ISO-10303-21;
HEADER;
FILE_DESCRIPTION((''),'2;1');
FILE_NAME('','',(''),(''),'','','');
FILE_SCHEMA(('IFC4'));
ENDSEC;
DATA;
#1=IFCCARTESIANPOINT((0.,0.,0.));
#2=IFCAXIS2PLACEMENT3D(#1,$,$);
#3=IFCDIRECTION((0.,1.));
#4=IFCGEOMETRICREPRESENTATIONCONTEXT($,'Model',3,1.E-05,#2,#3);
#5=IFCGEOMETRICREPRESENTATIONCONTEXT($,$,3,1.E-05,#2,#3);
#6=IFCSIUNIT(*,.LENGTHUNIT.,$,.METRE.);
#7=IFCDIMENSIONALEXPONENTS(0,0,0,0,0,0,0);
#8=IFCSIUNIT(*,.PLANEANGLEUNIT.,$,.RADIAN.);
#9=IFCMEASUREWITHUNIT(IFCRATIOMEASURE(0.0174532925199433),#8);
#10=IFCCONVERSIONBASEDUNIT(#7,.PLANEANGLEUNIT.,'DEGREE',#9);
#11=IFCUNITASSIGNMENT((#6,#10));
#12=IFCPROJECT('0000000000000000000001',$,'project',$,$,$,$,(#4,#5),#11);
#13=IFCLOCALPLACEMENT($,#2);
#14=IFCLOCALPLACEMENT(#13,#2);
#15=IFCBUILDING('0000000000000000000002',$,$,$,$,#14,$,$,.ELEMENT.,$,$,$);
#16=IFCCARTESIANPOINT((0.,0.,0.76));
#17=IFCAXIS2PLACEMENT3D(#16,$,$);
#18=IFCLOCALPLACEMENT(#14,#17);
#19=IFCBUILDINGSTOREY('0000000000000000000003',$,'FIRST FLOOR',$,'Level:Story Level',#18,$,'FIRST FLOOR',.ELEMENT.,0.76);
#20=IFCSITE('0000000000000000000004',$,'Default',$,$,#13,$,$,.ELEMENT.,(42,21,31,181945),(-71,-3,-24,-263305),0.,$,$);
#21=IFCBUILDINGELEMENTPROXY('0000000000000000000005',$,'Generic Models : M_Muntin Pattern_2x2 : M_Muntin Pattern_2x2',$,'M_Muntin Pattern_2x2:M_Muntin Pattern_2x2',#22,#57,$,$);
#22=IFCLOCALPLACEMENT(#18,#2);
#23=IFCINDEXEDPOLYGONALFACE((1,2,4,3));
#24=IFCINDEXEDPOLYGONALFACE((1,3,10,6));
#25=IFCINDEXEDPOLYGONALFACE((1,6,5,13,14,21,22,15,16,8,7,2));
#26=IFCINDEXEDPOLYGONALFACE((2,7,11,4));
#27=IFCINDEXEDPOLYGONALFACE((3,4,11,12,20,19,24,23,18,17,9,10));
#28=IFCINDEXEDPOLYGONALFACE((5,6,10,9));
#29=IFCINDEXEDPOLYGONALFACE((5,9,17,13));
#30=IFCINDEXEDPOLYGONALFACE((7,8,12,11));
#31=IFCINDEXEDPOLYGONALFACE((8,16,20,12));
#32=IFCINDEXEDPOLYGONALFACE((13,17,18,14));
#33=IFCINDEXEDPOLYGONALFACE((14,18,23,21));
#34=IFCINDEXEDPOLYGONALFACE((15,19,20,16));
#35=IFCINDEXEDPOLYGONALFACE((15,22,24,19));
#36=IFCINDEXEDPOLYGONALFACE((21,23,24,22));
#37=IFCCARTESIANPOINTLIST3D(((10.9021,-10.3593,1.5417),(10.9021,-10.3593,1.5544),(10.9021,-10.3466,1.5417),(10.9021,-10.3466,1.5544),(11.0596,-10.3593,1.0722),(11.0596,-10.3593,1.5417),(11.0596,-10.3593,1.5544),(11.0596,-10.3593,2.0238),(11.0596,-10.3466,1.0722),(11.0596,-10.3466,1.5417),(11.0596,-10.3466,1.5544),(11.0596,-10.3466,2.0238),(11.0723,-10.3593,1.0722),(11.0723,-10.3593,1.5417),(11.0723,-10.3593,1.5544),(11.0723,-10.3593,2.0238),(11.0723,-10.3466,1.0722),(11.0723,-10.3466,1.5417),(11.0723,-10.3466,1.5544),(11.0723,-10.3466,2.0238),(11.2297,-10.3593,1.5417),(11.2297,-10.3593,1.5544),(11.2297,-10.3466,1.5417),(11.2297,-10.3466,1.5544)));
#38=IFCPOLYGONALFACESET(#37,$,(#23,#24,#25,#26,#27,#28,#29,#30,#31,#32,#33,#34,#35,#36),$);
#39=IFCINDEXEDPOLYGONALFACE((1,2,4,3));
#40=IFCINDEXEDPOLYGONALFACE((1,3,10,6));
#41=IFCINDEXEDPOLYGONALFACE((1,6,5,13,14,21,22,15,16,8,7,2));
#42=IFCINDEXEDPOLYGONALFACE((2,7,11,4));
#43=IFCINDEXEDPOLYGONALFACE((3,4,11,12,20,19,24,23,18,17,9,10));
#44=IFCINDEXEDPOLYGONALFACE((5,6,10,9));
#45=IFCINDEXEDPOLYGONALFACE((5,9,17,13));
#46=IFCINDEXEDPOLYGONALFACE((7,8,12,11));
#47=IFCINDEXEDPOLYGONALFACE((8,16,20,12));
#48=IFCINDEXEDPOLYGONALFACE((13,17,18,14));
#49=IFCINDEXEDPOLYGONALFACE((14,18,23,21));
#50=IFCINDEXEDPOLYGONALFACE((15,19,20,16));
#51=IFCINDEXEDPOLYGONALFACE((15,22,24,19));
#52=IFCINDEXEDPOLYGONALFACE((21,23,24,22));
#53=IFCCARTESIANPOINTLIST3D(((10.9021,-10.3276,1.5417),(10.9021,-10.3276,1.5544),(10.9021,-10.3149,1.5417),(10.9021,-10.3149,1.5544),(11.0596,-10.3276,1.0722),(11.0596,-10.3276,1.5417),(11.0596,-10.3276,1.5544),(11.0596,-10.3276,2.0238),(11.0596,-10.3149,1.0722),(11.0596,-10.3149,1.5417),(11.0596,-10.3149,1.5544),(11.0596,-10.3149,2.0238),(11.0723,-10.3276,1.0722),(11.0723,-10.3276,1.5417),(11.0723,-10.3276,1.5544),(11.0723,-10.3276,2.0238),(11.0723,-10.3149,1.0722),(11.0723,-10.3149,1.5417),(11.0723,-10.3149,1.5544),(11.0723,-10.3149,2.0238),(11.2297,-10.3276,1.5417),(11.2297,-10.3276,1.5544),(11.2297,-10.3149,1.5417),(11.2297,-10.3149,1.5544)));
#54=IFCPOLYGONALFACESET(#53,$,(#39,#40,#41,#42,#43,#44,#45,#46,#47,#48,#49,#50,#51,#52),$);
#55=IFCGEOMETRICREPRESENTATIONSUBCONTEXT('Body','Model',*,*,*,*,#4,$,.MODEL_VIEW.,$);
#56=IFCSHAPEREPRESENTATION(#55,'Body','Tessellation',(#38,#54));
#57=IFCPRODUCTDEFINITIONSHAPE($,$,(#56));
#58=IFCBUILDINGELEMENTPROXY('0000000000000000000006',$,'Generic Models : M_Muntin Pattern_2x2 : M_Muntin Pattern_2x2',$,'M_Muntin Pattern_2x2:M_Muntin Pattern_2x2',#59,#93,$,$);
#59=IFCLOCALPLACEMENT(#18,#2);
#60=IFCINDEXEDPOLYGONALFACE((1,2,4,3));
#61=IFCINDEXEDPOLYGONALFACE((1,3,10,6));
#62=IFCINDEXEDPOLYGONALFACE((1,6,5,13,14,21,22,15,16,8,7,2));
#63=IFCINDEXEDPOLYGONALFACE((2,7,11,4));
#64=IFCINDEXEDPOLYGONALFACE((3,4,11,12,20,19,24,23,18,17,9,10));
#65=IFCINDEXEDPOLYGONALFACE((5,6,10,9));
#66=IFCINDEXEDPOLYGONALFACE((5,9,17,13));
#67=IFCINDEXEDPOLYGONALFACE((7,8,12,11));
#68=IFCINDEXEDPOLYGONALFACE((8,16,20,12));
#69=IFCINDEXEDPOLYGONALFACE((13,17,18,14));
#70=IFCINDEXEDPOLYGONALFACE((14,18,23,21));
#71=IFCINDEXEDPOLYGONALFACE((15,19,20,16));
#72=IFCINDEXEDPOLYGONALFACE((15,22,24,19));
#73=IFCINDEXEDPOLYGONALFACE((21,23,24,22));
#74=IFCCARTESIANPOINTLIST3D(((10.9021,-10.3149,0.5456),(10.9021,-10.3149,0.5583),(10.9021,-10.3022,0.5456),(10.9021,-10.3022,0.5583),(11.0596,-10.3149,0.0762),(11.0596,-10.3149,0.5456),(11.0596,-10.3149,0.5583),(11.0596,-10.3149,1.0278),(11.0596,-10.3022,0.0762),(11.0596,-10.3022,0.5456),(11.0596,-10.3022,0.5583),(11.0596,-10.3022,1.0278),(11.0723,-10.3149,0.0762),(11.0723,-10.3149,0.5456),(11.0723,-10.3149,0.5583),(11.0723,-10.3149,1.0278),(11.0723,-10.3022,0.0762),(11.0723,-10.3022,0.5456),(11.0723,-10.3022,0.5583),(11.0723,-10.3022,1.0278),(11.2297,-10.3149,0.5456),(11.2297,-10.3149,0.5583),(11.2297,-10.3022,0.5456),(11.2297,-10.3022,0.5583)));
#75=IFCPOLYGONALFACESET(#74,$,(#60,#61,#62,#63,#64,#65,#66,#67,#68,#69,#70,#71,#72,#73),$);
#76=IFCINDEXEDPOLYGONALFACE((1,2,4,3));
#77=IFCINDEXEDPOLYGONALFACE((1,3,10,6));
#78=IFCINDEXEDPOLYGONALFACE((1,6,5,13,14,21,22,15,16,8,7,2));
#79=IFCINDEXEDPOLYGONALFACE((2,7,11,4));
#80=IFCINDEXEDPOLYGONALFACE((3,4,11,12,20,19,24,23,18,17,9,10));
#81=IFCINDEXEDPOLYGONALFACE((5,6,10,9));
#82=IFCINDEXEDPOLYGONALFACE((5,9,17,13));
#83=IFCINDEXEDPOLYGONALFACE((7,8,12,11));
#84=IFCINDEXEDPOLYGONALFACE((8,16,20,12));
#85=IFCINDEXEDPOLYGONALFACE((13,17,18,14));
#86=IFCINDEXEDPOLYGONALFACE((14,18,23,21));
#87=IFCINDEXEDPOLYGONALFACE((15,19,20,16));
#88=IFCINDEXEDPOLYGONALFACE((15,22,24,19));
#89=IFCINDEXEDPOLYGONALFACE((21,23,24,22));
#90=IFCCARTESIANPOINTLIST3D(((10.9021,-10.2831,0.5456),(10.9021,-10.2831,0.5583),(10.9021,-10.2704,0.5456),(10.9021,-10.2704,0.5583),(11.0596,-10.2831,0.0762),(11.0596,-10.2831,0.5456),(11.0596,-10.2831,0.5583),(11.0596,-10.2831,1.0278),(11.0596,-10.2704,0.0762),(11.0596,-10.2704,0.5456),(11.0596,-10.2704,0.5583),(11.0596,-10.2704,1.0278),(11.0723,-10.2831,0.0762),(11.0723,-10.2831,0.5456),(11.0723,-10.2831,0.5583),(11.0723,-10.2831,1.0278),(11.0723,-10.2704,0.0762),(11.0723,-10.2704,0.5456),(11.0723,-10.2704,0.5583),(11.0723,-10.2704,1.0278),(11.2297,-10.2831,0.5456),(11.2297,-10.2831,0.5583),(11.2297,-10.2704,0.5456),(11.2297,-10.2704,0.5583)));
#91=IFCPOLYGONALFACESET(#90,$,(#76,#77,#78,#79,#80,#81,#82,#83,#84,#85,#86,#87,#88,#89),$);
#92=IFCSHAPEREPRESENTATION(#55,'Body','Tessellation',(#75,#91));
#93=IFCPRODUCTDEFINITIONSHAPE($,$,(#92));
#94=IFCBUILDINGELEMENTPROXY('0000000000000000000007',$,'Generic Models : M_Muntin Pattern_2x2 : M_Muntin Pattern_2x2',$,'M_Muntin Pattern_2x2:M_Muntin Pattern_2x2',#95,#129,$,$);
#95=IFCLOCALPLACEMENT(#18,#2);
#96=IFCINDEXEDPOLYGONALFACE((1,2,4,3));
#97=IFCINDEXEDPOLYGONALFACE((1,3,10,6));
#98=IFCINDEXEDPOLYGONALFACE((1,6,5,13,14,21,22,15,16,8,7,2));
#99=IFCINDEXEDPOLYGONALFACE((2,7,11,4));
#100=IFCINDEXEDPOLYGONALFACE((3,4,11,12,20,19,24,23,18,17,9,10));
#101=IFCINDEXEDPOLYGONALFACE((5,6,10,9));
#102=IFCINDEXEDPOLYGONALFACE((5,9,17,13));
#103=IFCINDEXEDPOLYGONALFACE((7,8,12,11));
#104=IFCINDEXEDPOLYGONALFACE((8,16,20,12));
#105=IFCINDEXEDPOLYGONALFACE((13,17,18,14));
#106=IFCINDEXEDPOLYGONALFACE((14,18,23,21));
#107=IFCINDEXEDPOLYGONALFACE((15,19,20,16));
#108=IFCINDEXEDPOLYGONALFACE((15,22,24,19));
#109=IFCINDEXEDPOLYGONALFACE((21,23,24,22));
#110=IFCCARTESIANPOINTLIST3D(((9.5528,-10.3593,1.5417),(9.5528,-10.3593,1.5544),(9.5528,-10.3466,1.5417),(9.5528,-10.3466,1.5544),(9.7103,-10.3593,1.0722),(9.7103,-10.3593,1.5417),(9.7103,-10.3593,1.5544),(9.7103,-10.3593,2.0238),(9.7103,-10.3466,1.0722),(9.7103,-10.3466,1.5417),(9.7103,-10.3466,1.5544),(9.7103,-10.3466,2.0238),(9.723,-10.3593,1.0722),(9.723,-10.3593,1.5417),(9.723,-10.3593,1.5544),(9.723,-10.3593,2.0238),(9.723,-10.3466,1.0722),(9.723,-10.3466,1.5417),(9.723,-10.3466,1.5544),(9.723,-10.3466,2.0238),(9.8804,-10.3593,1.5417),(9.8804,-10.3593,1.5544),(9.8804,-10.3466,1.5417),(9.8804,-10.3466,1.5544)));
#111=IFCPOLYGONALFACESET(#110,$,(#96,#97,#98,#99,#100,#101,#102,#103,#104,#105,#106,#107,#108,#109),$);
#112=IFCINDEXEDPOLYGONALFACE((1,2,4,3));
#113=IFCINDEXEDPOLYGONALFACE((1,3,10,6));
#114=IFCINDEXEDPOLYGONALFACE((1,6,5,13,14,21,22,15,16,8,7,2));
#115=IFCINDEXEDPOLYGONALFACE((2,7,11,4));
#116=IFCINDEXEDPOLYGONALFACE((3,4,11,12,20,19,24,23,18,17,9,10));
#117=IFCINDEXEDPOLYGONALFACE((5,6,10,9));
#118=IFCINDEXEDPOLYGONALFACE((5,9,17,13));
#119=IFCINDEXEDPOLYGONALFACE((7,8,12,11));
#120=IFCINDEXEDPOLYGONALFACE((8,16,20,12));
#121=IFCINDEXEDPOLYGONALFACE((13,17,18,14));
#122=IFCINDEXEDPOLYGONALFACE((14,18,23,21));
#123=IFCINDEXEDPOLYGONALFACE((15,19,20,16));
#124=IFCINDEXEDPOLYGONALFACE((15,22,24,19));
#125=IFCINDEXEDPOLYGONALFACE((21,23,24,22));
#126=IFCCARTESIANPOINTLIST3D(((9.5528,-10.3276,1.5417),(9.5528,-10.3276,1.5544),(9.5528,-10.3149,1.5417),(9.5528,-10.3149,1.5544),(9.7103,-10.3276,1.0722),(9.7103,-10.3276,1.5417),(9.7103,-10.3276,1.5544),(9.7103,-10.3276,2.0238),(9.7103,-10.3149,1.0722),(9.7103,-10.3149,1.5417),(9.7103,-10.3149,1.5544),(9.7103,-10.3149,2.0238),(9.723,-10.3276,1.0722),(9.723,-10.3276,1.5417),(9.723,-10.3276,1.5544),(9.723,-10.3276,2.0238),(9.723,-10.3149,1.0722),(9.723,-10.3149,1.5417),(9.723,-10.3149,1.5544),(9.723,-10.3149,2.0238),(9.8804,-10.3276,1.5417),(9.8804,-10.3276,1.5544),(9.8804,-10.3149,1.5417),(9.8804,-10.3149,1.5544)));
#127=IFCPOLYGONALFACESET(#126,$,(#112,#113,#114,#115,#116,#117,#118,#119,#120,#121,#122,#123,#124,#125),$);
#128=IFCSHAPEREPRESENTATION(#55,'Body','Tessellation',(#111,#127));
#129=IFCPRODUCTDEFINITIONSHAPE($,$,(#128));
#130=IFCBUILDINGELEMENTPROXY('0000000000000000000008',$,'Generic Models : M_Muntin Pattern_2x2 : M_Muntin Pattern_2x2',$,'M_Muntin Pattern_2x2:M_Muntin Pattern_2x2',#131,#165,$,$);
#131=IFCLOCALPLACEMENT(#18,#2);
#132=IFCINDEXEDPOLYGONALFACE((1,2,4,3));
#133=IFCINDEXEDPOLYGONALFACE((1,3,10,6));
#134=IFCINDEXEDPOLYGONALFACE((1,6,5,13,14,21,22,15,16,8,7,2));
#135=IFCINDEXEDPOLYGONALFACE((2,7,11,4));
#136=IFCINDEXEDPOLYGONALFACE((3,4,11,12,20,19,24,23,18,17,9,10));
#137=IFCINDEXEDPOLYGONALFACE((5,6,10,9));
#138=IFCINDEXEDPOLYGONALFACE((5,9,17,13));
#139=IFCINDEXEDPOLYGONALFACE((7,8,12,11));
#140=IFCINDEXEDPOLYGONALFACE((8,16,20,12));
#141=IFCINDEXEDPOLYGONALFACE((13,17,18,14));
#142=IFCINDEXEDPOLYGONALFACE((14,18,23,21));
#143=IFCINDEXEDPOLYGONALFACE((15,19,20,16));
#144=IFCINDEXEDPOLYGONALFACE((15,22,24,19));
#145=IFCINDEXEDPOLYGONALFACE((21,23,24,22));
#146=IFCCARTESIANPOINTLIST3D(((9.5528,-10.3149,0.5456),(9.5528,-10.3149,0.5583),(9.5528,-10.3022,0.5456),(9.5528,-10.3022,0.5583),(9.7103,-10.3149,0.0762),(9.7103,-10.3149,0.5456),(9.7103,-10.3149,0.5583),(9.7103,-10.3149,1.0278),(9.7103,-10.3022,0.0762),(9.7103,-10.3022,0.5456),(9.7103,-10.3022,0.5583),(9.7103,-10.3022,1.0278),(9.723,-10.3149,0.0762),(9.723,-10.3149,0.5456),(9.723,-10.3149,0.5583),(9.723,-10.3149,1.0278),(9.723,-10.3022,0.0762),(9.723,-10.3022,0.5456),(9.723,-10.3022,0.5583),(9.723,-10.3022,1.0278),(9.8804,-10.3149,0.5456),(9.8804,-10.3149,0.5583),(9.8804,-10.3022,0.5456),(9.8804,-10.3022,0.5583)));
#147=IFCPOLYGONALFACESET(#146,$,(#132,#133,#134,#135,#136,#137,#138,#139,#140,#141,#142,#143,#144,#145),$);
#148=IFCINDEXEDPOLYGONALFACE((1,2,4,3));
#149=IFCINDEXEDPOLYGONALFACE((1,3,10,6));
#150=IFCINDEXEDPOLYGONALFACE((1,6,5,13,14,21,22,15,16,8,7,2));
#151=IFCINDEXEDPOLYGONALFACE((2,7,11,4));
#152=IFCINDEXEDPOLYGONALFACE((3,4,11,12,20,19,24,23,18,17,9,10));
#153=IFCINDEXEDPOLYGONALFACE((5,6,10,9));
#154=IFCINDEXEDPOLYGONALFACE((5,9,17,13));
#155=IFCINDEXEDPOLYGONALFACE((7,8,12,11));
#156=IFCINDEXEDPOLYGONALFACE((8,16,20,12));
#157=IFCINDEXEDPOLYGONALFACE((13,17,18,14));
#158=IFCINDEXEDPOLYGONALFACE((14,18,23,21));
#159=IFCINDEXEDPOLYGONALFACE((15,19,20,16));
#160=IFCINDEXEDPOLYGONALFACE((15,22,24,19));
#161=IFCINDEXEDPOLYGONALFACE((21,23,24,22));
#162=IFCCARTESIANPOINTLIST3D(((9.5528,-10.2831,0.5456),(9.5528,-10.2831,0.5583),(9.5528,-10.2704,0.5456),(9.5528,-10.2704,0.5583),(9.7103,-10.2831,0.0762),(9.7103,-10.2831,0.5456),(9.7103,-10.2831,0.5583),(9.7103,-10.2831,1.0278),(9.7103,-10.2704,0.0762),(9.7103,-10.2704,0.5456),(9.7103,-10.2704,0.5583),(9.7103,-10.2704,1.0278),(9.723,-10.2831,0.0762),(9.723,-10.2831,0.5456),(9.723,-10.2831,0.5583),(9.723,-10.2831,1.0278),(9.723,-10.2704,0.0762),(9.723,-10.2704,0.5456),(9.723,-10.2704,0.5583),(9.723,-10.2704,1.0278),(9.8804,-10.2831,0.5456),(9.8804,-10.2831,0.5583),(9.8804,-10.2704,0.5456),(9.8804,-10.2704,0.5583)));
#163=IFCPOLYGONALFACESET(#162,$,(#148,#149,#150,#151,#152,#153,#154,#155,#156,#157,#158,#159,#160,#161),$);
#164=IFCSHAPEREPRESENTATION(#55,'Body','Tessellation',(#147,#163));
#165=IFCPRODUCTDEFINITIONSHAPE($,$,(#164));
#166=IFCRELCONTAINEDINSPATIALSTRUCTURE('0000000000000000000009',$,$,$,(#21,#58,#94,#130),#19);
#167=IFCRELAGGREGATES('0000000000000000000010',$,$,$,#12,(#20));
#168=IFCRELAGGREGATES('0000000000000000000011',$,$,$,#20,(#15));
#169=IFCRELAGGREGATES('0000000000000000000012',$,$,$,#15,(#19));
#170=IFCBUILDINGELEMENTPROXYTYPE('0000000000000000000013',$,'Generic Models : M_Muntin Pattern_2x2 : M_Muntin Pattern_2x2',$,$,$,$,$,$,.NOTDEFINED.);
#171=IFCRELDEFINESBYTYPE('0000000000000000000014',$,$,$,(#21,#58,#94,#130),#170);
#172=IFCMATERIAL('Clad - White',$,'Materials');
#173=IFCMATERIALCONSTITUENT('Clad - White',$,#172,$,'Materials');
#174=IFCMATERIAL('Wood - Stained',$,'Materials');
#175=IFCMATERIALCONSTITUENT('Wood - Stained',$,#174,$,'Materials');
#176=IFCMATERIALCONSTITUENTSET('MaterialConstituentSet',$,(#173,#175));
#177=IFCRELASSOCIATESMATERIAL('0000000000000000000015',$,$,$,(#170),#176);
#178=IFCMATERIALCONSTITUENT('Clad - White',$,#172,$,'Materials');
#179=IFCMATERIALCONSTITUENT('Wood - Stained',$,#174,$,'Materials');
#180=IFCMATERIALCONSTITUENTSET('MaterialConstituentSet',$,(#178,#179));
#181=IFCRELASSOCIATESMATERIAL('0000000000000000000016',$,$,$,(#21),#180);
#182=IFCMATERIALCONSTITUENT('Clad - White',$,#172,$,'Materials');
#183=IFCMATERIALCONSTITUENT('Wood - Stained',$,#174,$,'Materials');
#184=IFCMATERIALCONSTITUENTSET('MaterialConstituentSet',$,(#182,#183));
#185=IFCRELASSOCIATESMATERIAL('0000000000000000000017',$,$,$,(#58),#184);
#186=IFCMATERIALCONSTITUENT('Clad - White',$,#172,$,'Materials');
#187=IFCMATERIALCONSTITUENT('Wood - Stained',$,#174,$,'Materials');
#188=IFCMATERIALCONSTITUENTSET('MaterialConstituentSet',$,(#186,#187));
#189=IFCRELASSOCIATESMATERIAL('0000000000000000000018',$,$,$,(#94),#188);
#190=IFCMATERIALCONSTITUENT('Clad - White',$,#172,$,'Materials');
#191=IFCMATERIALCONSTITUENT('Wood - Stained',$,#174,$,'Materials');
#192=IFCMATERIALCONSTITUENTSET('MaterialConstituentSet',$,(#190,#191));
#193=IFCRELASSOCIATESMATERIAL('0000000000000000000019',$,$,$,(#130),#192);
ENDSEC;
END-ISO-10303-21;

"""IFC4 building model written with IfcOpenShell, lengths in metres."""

from ifc_helpers import new_model, entity, si_unit, converted_unit, direction, frame, origin, place, context, subcontext, project, spatial, polyline, outline, extrude, source, transform, mapped, material, constituent, constituent_set, type_object, type_shapes, element, save


model = new_model("IFC4")

# Units and contexts
model_context = context("Model", 3, precision=1e-05, world=origin(), true_north=direction((0.0, 1.0)))
context_of_model = context(None, 3, precision=1e-05, world=origin(), true_north=direction((0.0, 1.0)))
body_context = subcontext(model_context, "Body", "Model", "MODEL_VIEW")
ifc_project = project(units=[si_unit("LENGTHUNIT", "METRE"), converted_unit("PLANEANGLEUNIT", "DEGREE", entity("IfcRatioMeasure", 0.0174532925199433), si_unit("PLANEANGLEUNIT", "RADIAN"), dimensions=[0, 0, 0, 0, 0, 0, 0])], contexts=[model_context, context_of_model])

# Site, building, storey
site_placement = place(None, origin())
site = spatial("IfcSite", under=ifc_project, at=site_placement, Name="Default", CompositionType="ELEMENT", RefLatitude=(42, 21, 31, 181945), RefLongitude=(-71, -3, -24, -263305), RefElevation=0.0)
building_placement = place(site_placement, origin())
building = spatial("IfcBuilding", under=site, at=building_placement, CompositionType="ELEMENT")
storey_placement = place(building_placement, frame((0.0, 0.0, 0.76)))
storey = spatial("IfcBuildingStorey", under=building, at=storey_placement, Name="FIRST FLOOR", ObjectType="Level:Story Level", LongName="FIRST FLOOR", CompositionType="ELEMENT", Elevation=0.76)

# Building element proxies
ifc_material_1 = material(Name="Clad - White", Category="Materials")
ifc_constituent_1 = constituent(ifc_material_1, Name="Clad - White", Category="Materials")
ifc_material_2 = material(Name="Wood - Stained", Category="Materials")
ifc_constituent_2 = constituent(ifc_material_2, Name="Wood - Stained", Category="Materials")
ifc_constituent_set_1 = constituent_set(constituents=[ifc_constituent_1, ifc_constituent_2], Name="MaterialConstituentSet")
ifc_constituent_3 = constituent(ifc_material_1, Name="Clad - White", Category="Materials")
ifc_constituent_4 = constituent(ifc_material_2, Name="Wood - Stained", Category="Materials")
ifc_constituent_set_2 = constituent_set(constituents=[ifc_constituent_3, ifc_constituent_4], Name="MaterialConstituentSet")
building_element_proxy_type_1 = type_object("IfcBuildingElementProxyType", Name="Generic Models : M_Muntin Pattern_2x2 : M_Muntin Pattern_2x2", PredefinedType="NOTDEFINED", material=ifc_constituent_set_2)
shared_shape_1 = source(origin(), body_context, "Body", "SweptSolid", [
    extrude(outline(polyline([(0.0064, -0.0064), (0.4758, -0.0064), (0.4758, 0.0063), (0.0064, 0.0063), (0.0064, 0.1638), (-0.0063, 0.1638), (-0.0063, 0.0063), (-0.4758, 0.0063), (-0.4758, -0.0064), (-0.0063, -0.0064), (-0.0063, -0.1638), (0.0064, -0.1638), (0.0064, -0.0064)])), frame((0.0, 0.0095, 0.4758), z_axis=(0.0, 1.0, 0.0), x_axis=(0.0, 0.0, 1.0)), (0.0, 0.0, 1.0), 0.0127),
    extrude(outline(polyline([(0.0064, -0.0064), (0.4758, -0.0064), (0.4758, 0.0063), (0.0064, 0.0063), (0.0064, 0.1638), (-0.0063, 0.1638), (-0.0063, 0.0063), (-0.4758, 0.0063), (-0.4758, -0.0064), (-0.0063, -0.0064), (-0.0063, -0.1638), (0.0064, -0.1638), (0.0064, -0.0064)])), frame((0.0, -0.0222, 0.4758), z_axis=(0.0, 1.0, 0.0), x_axis=(0.0, 0.0, 1.0)), (0.0, 0.0, 1.0), 0.0127),
])
type_shapes(building_element_proxy_type_1, [shared_shape_1])
proxy_1_placement = place(storey_placement, frame((11.0659, -10.3371, 1.0722), z_axis=(0.0, 0.0, 1.0), x_axis=(-1.0, 0.0, 0.0)))
element("IfcBuildingElementProxy", 1, at=proxy_1_placement, inside=storey, type_object=building_element_proxy_type_1, material=ifc_constituent_set_1, Name="Generic Models : M_Muntin Pattern_2x2 : M_Muntin Pattern_2x2", ObjectType="M_Muntin Pattern_2x2:M_Muntin Pattern_2x2", context=body_context, shape_type="MappedRepresentation", body=[
    mapped(shared_shape_1, transform((0.0, 0.0, 0.0), scale=1.0)),
])
ifc_constituent_5 = constituent(ifc_material_1, Name="Clad - White", Category="Materials")
ifc_constituent_6 = constituent(ifc_material_2, Name="Wood - Stained", Category="Materials")
ifc_constituent_set_3 = constituent_set(constituents=[ifc_constituent_5, ifc_constituent_6], Name="MaterialConstituentSet")
proxy_2_placement = place(storey_placement, frame((11.0659, -10.2926, 0.0762), z_axis=(0.0, 0.0, 1.0), x_axis=(-1.0, 0.0, 0.0)))
element("IfcBuildingElementProxy", 2, at=proxy_2_placement, inside=storey, type_object=building_element_proxy_type_1, material=ifc_constituent_set_3, Name="Generic Models : M_Muntin Pattern_2x2 : M_Muntin Pattern_2x2", ObjectType="M_Muntin Pattern_2x2:M_Muntin Pattern_2x2", context=body_context, shape_type="MappedRepresentation", body=[
    mapped(shared_shape_1, transform((0.0, 0.0, 0.0), scale=1.0)),
])
ifc_constituent_7 = constituent(ifc_material_1, Name="Clad - White", Category="Materials")
ifc_constituent_8 = constituent(ifc_material_2, Name="Wood - Stained", Category="Materials")
ifc_constituent_set_4 = constituent_set(constituents=[ifc_constituent_7, ifc_constituent_8], Name="MaterialConstituentSet")
proxy_3_placement = place(storey_placement, frame((9.7166, -10.3371, 1.0722), z_axis=(0.0, 0.0, 1.0), x_axis=(-1.0, 0.0, 0.0)))
element("IfcBuildingElementProxy", 3, at=proxy_3_placement, inside=storey, type_object=building_element_proxy_type_1, material=ifc_constituent_set_4, Name="Generic Models : M_Muntin Pattern_2x2 : M_Muntin Pattern_2x2", ObjectType="M_Muntin Pattern_2x2:M_Muntin Pattern_2x2", context=body_context, shape_type="MappedRepresentation", body=[
    mapped(shared_shape_1, transform((0.0, 0.0, 0.0), scale=1.0)),
])
ifc_constituent_9 = constituent(ifc_material_1, Name="Clad - White", Category="Materials")
ifc_constituent_10 = constituent(ifc_material_2, Name="Wood - Stained", Category="Materials")
ifc_constituent_set_5 = constituent_set(constituents=[ifc_constituent_9, ifc_constituent_10], Name="MaterialConstituentSet")
proxy_4_placement = place(storey_placement, frame((9.7166, -10.2926, 0.0762), z_axis=(0.0, 0.0, 1.0), x_axis=(-1.0, 0.0, 0.0)))
element("IfcBuildingElementProxy", 4, at=proxy_4_placement, inside=storey, type_object=building_element_proxy_type_1, material=ifc_constituent_set_5, Name="Generic Models : M_Muntin Pattern_2x2 : M_Muntin Pattern_2x2", ObjectType="M_Muntin Pattern_2x2:M_Muntin Pattern_2x2", context=body_context, shape_type="MappedRepresentation", body=[
    mapped(shared_shape_1, transform((0.0, 0.0, 0.0), scale=1.0)),
])

save(model, "model.ifc")
